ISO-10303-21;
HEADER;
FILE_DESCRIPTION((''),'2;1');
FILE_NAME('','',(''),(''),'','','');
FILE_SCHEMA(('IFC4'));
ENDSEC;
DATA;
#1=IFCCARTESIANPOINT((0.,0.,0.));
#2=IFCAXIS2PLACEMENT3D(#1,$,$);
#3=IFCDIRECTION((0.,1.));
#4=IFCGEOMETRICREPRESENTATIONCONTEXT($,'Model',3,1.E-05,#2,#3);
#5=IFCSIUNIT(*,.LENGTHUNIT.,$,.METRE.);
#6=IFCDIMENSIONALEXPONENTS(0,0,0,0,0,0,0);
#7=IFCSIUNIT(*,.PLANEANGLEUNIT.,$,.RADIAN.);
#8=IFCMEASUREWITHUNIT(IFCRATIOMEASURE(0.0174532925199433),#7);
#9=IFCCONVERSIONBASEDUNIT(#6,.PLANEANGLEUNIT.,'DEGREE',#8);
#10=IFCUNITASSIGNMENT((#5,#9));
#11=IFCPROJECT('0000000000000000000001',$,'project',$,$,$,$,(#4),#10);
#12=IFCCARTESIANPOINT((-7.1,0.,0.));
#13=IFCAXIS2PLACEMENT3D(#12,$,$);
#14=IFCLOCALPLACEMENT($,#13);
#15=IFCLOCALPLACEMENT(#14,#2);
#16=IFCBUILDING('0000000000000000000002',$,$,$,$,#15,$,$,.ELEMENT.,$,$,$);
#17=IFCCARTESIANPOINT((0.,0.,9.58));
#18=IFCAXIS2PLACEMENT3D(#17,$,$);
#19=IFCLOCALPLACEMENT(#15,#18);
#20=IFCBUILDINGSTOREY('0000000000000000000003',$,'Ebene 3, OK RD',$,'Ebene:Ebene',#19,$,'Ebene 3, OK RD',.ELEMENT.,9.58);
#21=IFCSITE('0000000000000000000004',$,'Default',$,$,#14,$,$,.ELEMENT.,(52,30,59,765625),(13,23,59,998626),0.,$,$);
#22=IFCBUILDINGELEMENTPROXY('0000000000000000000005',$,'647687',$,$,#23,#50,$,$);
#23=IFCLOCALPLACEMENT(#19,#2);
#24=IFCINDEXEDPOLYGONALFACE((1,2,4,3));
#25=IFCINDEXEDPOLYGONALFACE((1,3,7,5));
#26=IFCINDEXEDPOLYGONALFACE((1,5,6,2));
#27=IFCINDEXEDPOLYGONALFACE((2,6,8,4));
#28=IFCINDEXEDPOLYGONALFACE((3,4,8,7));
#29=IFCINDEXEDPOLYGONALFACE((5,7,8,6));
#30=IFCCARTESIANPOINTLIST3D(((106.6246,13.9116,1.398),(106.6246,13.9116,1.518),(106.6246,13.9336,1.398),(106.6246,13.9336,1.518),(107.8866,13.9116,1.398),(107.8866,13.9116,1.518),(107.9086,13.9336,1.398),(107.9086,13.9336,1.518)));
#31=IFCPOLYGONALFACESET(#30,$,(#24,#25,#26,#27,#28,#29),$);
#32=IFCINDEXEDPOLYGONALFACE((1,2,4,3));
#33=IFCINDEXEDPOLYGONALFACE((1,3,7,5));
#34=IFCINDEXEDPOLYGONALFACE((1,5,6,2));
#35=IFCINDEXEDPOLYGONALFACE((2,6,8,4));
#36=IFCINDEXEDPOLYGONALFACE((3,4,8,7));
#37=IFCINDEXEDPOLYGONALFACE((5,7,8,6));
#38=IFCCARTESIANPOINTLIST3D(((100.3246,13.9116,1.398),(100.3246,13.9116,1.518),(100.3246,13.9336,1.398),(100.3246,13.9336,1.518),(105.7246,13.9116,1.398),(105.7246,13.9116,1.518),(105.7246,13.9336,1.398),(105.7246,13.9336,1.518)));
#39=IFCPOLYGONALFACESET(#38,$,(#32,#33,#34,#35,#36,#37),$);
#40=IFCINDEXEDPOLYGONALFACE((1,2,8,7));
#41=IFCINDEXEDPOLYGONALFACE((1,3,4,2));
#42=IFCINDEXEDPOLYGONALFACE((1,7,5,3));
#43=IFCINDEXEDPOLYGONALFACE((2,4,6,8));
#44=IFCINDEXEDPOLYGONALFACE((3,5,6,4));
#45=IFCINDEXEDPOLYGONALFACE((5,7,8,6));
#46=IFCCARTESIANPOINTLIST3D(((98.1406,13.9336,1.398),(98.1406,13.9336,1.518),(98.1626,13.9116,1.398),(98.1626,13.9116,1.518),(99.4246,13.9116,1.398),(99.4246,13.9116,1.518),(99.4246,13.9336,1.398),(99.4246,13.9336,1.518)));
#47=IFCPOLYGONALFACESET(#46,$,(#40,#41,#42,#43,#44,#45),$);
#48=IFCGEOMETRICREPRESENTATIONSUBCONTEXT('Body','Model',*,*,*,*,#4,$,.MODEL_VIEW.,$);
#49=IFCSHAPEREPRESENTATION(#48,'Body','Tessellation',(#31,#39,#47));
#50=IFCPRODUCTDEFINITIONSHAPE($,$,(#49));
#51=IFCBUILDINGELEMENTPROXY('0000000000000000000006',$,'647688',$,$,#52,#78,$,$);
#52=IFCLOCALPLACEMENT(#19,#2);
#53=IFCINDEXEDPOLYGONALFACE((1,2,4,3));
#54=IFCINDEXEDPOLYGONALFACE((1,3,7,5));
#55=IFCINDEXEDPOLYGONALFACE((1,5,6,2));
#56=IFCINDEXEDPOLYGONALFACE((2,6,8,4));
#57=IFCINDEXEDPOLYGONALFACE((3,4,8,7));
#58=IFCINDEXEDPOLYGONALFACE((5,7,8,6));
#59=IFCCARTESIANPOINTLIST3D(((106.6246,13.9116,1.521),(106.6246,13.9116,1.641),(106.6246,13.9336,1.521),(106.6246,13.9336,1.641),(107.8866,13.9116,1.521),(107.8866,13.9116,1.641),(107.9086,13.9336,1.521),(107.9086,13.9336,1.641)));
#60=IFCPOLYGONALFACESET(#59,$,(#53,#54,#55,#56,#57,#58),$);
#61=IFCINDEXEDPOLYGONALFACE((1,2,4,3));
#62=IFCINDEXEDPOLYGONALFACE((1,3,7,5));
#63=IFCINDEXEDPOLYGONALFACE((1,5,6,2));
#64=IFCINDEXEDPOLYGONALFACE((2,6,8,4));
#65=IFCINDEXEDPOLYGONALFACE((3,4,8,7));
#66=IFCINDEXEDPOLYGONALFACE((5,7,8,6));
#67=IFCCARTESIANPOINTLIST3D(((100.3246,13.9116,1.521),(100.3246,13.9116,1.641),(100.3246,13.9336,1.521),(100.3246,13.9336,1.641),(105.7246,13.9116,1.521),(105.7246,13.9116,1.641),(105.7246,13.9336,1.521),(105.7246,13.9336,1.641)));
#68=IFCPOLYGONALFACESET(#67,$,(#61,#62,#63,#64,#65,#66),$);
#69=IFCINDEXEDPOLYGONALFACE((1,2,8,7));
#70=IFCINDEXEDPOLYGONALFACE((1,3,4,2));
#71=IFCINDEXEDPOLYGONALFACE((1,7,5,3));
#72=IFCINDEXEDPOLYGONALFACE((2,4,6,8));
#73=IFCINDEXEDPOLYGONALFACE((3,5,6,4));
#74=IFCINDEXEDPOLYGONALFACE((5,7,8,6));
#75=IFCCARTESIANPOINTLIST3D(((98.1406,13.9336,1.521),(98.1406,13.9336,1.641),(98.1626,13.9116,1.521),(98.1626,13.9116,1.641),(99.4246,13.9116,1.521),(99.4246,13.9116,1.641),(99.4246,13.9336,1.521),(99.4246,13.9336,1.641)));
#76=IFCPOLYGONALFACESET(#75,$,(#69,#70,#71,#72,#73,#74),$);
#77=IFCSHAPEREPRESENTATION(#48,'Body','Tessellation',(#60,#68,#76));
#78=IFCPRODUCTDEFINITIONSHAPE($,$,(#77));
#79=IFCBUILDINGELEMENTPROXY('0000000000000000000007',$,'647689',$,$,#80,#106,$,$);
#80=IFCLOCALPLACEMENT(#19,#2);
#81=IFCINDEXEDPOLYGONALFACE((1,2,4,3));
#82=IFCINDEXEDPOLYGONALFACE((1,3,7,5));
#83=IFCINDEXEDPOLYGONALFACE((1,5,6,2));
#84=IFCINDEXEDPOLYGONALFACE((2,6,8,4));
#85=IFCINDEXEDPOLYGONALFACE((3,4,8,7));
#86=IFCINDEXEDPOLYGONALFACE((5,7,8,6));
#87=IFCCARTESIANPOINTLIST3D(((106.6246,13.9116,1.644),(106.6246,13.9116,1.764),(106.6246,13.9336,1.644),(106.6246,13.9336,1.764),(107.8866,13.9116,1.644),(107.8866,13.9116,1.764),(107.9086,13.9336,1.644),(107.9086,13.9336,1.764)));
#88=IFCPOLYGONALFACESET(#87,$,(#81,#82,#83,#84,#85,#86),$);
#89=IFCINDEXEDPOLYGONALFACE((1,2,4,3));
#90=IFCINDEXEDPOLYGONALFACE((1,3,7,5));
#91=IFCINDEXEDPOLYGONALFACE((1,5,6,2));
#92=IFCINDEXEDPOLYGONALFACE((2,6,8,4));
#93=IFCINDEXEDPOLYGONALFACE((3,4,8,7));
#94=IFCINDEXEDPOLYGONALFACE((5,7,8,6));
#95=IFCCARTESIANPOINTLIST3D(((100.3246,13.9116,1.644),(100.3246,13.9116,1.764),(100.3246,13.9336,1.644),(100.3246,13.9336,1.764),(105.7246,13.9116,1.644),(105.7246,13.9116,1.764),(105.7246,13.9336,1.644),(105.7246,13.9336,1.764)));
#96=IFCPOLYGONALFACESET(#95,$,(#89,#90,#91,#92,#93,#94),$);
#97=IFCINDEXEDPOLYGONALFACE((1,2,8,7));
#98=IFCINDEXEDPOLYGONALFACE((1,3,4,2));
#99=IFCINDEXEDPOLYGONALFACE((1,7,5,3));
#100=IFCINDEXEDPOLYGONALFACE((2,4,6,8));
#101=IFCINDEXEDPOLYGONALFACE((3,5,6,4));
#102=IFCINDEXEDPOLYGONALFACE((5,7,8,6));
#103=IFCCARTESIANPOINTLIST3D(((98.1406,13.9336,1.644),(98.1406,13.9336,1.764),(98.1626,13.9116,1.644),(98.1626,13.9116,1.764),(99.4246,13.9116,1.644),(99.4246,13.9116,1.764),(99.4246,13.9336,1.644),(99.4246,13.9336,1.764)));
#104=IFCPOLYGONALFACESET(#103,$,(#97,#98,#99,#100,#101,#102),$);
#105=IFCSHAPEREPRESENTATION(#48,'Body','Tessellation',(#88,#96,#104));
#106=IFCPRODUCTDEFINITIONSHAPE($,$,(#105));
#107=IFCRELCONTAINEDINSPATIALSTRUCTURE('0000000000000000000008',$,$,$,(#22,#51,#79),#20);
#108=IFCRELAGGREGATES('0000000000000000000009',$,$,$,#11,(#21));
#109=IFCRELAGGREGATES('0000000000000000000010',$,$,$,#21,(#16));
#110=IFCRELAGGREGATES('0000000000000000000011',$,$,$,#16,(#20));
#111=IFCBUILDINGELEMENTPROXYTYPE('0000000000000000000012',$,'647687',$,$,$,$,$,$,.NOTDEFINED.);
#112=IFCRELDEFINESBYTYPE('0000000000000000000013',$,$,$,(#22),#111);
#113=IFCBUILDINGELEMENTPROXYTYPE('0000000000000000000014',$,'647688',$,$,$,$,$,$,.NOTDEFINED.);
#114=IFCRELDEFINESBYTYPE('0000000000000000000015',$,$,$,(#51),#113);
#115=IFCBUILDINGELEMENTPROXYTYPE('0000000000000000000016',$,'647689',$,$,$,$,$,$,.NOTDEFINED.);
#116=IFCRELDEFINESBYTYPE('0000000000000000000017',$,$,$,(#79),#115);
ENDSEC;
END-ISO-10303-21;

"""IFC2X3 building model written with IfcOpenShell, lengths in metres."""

from ifc_helpers import new_model, entity, si_unit, converted_unit, direction, frame, frame_2d, origin, place, context, subcontext, project, spatial, polyline, rectangle, outline, extrude, type_object, element, save


model = new_model("IFC2X3")

# Units and contexts
model_context = context("Model", 3, precision=1e-05, world=origin(), true_north=direction((0.0, 1.0)))
body_context = subcontext(model_context, "Body", "Model", "MODEL_VIEW")
ifc_project = project(units=[si_unit("LENGTHUNIT", "METRE"), converted_unit("PLANEANGLEUNIT", "DEGREE", entity("IfcRatioMeasure", 0.0174532925199433), si_unit("PLANEANGLEUNIT", "RADIAN"), dimensions=[0, 0, 0, 0, 0, 0, 0])], contexts=[model_context])

# Site, building, storey
site_placement = place(None, frame((-7.1, 0.0, 0.0)))
site = spatial("IfcSite", under=ifc_project, at=site_placement, Name="Default", CompositionType="ELEMENT", RefLatitude=(52, 30, 59, 765625), RefLongitude=(13, 23, 59, 998626), RefElevation=0.0)
building_placement = place(site_placement, origin())
building = spatial("IfcBuilding", under=site, at=building_placement, CompositionType="ELEMENT")
storey_placement = place(building_placement, frame((0.0, 0.0, 9.58)))
storey = spatial("IfcBuildingStorey", under=building, at=storey_placement, Name="Ebene 3, OK RD", ObjectType="Ebene:Ebene", LongName="Ebene 3, OK RD", CompositionType="ELEMENT", Elevation=9.58)

# Building element proxies
building_element_proxy_type_1 = type_object("IfcBuildingElementProxyType", Name="647687", PredefinedType="NOTDEFINED")
proxy_1_placement = place(storey_placement, origin())
element("IfcBuildingElementProxy", 1, at=proxy_1_placement, inside=storey, type_object=building_element_proxy_type_1, Name="647687", context=body_context, shape_type="SweptSolid", body=[
    extrude(outline(polyline([(-0.6365, -0.011), (0.6255, -0.011), (0.6475, 0.011), (-0.6365, 0.011), (-0.6365, -0.011)])), frame((107.2611, 13.9226, 1.398)), (0.0, 0.0, 1.0), 0.12),
    extrude(rectangle(XDim=5.4, YDim=0.022, at=frame_2d((0.0, 0.0), x_axis=(1.0, 0.0))), frame((103.0246, 13.9226, 1.398)), (0.0, 0.0, 1.0), 0.12),
    extrude(outline(polyline([(-0.6255, -0.011), (0.6365, -0.011), (0.6365, 0.011), (-0.6475, 0.011), (-0.6255, -0.011)])), frame((98.7881, 13.9226, 1.398)), (0.0, 0.0, 1.0), 0.12),
])
building_element_proxy_type_2 = type_object("IfcBuildingElementProxyType", Name="647688", PredefinedType="NOTDEFINED")
proxy_2_placement = place(storey_placement, origin())
element("IfcBuildingElementProxy", 2, at=proxy_2_placement, inside=storey, type_object=building_element_proxy_type_2, Name="647688", context=body_context, shape_type="SweptSolid", body=[
    extrude(outline(polyline([(-0.6365, -0.011), (0.6255, -0.011), (0.6475, 0.011), (-0.6365, 0.011), (-0.6365, -0.011)])), frame((107.2611, 13.9226, 1.521)), (0.0, 0.0, 1.0), 0.12),
    extrude(rectangle(XDim=5.4, YDim=0.022, at=frame_2d((0.0, 0.0), x_axis=(1.0, 0.0))), frame((103.0246, 13.9226, 1.521)), (0.0, 0.0, 1.0), 0.12),
    extrude(outline(polyline([(-0.6255, -0.011), (0.6365, -0.011), (0.6365, 0.011), (-0.6475, 0.011), (-0.6255, -0.011)])), frame((98.7881, 13.9226, 1.521)), (0.0, 0.0, 1.0), 0.12),
])
building_element_proxy_type_3 = type_object("IfcBuildingElementProxyType", Name="647689", PredefinedType="NOTDEFINED")
proxy_3_placement = place(storey_placement, origin())
element("IfcBuildingElementProxy", 3, at=proxy_3_placement, inside=storey, type_object=building_element_proxy_type_3, Name="647689", context=body_context, shape_type="SweptSolid", body=[
    extrude(outline(polyline([(-0.6365, -0.011), (0.6255, -0.011), (0.6475, 0.011), (-0.6365, 0.011), (-0.6365, -0.011)])), frame((107.2611, 13.9226, 1.644)), (0.0, 0.0, 1.0), 0.12),
    extrude(rectangle(XDim=5.4, YDim=0.022, at=frame_2d((0.0, 0.0), x_axis=(1.0, 0.0))), frame((103.0246, 13.9226, 1.644)), (0.0, 0.0, 1.0), 0.12),
    extrude(outline(polyline([(-0.6255, -0.011), (0.6365, -0.011), (0.6365, 0.011), (-0.6475, 0.011), (-0.6255, -0.011)])), frame((98.7881, 13.9226, 1.644)), (0.0, 0.0, 1.0), 0.12),
])

save(model, "model.ifc")
